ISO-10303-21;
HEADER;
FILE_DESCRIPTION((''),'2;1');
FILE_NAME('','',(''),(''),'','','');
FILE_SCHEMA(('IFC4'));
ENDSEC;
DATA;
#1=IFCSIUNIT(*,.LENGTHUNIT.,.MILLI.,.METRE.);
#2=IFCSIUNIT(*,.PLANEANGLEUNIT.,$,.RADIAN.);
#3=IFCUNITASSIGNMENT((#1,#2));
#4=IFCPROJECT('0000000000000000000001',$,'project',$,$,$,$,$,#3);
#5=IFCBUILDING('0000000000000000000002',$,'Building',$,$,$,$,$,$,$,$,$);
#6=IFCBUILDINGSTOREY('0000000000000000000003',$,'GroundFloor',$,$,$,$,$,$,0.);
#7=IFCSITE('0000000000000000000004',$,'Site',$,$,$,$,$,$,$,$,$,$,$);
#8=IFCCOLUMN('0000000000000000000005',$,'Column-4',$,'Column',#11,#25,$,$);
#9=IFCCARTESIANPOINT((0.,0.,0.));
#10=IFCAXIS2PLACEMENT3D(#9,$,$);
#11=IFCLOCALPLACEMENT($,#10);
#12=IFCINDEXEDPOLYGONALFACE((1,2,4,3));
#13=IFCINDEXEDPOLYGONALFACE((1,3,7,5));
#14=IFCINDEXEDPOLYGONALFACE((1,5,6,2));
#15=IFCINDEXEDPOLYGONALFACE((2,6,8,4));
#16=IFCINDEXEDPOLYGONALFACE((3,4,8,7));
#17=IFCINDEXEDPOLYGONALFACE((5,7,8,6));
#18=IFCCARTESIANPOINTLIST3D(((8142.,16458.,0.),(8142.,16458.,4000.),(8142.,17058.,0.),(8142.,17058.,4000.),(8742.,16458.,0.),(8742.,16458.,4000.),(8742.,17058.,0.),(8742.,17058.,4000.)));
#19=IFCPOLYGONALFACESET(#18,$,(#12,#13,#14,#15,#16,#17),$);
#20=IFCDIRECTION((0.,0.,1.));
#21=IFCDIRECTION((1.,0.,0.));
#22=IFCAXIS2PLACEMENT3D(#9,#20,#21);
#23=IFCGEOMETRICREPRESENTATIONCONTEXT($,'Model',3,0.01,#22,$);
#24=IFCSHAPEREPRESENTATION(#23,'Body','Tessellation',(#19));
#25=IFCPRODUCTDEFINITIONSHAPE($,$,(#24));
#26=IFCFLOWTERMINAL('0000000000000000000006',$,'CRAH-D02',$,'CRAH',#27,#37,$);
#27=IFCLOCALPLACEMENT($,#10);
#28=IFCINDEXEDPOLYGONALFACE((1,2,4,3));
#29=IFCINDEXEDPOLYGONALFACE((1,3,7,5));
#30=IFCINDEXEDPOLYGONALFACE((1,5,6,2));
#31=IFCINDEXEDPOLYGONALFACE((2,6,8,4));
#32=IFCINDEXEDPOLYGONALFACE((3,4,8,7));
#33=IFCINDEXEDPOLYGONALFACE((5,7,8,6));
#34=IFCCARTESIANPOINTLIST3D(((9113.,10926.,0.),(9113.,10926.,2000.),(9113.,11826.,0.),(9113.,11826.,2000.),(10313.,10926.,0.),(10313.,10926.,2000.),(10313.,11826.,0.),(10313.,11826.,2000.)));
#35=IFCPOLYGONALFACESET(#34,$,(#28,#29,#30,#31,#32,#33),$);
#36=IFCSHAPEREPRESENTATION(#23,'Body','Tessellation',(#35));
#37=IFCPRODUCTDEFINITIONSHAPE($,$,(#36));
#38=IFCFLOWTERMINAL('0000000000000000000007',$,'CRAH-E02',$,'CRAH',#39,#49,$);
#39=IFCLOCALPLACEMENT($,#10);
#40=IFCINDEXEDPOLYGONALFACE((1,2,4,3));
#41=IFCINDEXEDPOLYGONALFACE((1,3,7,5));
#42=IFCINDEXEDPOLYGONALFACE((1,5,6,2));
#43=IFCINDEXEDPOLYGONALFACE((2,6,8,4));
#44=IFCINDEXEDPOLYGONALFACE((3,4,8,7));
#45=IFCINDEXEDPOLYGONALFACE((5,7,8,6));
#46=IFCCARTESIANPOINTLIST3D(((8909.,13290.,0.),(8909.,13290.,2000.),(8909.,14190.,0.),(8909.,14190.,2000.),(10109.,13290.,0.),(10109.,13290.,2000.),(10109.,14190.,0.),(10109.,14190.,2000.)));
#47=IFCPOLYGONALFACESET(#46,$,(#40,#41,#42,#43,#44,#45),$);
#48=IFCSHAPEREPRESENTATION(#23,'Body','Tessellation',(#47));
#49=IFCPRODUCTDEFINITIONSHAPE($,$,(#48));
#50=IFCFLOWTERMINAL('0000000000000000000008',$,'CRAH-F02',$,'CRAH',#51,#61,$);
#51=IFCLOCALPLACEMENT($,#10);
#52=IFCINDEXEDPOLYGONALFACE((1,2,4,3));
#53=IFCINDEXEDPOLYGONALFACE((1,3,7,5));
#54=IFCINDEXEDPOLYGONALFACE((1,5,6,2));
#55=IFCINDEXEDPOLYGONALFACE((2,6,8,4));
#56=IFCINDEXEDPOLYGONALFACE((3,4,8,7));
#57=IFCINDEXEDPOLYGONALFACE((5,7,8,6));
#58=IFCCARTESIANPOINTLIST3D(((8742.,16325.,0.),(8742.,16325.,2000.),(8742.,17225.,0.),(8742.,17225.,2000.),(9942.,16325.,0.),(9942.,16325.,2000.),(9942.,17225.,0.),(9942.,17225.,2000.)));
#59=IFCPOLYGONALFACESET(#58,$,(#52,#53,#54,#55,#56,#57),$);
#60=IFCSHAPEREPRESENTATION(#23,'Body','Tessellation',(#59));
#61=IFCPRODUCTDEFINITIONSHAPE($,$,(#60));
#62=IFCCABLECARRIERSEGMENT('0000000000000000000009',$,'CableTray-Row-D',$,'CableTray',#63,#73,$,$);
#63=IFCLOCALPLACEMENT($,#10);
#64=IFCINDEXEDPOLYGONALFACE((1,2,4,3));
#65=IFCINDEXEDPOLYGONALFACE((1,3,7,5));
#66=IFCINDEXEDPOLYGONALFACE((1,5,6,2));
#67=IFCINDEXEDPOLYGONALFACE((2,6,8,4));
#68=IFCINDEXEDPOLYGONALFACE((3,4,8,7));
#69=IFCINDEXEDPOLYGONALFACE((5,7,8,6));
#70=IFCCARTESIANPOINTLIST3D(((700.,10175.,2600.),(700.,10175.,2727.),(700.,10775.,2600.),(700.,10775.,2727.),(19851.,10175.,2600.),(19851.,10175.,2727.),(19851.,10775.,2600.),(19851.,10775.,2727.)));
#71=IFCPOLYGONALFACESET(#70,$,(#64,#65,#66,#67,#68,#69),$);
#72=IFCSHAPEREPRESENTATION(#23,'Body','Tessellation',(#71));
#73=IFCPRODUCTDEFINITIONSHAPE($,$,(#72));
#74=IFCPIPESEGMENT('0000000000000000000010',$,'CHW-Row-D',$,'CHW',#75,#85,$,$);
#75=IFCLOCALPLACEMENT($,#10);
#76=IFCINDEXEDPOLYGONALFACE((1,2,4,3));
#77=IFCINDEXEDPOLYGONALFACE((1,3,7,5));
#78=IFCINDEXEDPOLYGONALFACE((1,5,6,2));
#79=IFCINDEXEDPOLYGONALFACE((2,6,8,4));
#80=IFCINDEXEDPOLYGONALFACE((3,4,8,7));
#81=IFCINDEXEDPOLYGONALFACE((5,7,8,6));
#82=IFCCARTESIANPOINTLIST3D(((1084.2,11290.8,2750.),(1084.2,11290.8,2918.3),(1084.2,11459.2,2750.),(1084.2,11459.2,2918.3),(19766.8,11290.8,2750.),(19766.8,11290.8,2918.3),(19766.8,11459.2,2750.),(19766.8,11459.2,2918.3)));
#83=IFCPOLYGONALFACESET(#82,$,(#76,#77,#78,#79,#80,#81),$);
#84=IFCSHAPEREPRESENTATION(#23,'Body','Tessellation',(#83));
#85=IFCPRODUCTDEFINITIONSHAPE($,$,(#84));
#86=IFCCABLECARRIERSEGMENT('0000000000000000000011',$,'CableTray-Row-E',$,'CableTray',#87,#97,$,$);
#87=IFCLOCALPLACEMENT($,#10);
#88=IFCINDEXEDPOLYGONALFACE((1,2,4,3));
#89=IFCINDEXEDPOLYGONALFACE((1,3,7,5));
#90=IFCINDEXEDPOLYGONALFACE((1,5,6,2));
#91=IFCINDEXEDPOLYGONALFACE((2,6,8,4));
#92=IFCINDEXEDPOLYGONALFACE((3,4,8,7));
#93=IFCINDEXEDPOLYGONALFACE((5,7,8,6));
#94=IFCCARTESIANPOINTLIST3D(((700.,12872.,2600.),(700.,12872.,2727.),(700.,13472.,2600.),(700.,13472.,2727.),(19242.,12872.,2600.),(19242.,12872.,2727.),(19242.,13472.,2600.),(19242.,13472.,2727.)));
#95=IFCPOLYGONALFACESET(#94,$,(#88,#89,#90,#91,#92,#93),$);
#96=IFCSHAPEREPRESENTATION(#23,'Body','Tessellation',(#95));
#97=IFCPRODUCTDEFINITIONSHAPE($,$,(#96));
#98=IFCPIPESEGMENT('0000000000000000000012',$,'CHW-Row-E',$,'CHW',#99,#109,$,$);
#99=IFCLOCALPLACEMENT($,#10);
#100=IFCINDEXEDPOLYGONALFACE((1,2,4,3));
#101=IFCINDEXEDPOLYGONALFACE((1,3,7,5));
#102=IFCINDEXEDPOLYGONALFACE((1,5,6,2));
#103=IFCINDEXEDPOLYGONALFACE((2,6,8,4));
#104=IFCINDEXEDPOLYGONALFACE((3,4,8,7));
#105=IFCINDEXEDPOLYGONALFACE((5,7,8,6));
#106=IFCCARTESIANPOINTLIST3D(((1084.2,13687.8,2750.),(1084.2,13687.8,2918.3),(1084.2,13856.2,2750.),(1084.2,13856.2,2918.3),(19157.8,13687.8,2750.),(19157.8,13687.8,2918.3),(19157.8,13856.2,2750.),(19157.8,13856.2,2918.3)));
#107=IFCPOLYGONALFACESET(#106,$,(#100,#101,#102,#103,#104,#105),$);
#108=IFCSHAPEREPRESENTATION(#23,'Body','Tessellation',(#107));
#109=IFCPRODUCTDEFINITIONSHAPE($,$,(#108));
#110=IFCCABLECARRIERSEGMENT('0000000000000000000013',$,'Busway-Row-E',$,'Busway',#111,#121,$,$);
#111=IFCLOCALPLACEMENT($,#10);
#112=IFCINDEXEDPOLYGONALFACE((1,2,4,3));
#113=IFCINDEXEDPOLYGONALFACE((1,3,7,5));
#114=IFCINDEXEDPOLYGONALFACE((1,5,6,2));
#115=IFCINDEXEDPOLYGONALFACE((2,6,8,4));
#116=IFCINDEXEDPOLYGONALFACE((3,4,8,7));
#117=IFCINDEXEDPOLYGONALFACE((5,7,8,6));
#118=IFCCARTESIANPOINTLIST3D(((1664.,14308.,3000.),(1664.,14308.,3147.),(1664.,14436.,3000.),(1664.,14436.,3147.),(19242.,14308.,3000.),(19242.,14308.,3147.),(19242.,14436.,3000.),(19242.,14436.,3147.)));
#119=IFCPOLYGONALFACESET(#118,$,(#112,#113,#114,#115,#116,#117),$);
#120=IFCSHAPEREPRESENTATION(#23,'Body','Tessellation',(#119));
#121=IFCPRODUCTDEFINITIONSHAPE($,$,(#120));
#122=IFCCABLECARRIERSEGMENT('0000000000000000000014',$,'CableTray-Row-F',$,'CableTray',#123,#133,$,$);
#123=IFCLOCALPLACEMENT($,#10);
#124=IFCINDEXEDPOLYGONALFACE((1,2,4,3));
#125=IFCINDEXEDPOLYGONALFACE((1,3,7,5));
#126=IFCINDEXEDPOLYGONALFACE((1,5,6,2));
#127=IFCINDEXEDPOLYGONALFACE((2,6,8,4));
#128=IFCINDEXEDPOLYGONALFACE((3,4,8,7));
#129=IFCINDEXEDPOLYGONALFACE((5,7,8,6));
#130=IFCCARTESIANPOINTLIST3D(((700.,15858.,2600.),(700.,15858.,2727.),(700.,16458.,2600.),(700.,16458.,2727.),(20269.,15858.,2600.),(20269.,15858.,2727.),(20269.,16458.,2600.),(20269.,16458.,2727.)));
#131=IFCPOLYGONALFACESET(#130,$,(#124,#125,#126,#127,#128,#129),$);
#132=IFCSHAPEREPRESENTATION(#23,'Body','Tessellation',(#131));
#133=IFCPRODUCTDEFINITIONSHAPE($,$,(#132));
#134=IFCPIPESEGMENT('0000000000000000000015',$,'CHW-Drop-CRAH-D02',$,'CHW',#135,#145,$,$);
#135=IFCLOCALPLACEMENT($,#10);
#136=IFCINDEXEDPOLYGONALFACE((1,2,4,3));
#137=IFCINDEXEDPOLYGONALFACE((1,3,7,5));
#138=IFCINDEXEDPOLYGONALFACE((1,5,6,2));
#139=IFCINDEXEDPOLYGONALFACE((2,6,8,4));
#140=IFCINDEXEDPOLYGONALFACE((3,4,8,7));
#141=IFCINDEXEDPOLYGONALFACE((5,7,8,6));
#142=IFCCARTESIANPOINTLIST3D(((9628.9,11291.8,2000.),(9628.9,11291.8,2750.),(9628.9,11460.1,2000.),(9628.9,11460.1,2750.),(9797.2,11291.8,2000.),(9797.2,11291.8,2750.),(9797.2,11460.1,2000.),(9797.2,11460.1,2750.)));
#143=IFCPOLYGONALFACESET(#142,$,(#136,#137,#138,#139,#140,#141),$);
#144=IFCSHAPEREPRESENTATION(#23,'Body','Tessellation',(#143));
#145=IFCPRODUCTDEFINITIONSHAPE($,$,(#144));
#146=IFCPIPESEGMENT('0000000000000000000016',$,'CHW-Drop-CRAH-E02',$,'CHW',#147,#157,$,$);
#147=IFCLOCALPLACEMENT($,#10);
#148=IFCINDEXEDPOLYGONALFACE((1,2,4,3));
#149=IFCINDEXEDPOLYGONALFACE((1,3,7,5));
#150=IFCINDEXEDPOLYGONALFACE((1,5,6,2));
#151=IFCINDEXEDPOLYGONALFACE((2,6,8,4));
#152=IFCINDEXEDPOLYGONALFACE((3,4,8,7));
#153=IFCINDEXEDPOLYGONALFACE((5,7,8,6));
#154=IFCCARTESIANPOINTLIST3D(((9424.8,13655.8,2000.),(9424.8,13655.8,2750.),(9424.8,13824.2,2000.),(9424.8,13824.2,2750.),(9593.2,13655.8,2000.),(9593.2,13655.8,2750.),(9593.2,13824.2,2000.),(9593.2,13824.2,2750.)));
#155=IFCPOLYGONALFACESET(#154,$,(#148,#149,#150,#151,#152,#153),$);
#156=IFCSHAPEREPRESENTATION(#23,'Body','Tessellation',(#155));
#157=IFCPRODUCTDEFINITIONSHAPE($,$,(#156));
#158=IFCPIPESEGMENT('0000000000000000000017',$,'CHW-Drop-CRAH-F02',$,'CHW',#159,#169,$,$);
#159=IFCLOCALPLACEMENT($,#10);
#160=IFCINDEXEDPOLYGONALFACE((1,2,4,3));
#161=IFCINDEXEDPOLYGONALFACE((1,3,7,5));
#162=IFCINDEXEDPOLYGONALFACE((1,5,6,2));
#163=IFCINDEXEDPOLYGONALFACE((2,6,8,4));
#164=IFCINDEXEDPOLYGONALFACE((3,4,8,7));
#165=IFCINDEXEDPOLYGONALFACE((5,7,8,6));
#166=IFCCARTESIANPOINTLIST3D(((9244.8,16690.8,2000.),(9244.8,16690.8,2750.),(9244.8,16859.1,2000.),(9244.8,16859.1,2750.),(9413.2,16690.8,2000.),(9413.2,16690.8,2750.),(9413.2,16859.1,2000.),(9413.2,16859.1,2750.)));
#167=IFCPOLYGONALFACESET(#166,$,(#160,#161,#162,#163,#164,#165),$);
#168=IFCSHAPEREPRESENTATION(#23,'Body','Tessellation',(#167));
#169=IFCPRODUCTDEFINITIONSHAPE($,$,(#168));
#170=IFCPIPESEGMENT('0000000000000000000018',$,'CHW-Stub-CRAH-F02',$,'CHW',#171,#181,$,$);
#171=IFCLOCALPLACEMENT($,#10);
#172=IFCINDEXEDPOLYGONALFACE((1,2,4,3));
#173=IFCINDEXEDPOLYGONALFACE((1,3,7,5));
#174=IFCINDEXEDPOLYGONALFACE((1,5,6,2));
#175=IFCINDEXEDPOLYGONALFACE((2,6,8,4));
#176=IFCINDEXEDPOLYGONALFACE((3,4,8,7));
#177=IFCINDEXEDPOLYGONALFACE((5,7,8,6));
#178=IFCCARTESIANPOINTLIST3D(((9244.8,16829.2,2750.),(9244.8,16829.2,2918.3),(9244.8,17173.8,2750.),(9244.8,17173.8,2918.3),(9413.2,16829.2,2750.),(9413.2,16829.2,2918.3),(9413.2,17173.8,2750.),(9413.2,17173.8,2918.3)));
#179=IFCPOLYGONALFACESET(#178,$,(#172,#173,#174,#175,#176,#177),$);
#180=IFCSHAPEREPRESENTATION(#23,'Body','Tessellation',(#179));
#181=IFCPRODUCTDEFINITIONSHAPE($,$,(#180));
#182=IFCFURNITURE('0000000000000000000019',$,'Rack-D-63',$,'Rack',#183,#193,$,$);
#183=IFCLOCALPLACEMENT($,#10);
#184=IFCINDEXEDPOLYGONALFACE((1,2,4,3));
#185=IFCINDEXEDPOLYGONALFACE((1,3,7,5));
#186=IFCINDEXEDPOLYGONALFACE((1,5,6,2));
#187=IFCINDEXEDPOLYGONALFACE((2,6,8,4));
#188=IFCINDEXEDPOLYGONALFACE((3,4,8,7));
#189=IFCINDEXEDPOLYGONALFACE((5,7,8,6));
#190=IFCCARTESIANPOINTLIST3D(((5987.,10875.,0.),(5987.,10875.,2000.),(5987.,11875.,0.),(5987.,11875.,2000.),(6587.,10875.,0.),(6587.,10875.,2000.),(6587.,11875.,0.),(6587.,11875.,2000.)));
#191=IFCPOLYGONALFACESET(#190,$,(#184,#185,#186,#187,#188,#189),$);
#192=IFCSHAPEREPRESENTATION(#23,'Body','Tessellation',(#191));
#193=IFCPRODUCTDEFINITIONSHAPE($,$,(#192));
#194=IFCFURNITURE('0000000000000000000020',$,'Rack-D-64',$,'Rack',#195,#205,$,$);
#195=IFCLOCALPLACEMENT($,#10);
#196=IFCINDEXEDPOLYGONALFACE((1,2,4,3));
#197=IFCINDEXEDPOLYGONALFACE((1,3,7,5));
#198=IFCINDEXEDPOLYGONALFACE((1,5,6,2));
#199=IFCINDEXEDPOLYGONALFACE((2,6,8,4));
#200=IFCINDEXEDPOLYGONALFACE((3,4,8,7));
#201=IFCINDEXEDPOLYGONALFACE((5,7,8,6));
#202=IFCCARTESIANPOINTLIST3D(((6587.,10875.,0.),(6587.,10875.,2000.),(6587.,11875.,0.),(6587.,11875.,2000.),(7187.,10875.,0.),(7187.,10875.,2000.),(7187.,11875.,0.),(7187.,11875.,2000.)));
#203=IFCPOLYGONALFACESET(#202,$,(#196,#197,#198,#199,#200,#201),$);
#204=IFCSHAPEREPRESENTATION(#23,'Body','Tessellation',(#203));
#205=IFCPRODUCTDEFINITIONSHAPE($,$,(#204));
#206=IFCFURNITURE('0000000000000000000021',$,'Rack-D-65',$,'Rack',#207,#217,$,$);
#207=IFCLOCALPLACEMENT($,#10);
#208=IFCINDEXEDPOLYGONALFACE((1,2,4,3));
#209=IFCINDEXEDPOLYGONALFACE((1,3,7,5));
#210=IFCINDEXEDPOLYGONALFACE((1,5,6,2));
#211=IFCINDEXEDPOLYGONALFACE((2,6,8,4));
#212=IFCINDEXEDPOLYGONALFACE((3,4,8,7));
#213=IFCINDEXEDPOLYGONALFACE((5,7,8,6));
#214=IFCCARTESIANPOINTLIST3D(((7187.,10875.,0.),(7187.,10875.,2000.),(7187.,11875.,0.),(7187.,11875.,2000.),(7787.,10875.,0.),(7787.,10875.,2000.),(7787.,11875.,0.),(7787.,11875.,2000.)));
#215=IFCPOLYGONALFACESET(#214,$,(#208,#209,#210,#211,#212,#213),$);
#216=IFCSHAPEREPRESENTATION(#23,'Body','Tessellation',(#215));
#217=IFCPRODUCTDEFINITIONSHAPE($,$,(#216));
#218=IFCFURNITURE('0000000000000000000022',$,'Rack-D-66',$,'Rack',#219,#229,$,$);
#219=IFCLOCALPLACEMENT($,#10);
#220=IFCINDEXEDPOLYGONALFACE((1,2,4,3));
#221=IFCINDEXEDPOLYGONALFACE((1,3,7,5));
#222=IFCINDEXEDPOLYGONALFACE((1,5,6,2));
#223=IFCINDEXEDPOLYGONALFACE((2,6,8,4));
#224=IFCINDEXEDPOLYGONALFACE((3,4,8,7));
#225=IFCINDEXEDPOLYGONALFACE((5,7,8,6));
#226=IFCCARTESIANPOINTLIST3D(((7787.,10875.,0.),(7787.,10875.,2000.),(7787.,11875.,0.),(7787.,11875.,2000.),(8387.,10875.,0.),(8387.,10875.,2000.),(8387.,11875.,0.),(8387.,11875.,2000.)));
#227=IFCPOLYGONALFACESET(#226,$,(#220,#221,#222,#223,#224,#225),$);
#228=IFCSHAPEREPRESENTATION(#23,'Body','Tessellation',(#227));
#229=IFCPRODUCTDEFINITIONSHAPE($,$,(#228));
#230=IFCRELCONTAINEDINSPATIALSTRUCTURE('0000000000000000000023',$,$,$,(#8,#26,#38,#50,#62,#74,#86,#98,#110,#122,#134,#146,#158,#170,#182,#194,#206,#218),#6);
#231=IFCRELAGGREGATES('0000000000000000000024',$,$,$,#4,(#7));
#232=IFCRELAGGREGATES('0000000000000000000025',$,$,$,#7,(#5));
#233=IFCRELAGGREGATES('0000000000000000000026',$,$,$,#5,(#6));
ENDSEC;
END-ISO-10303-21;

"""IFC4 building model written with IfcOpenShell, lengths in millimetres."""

from ifc_helpers import new_model, si_unit, frame, origin, origin_with_axes, origin_2d, place, context, project, spatial, rectangle, extrude, element, save


model = new_model("IFC4")

# Units and contexts
model_context = context("Model", 3, precision=0.01, world=origin_with_axes())
ifc_project = project(units=[si_unit("LENGTHUNIT", "METRE", prefix="MILLI"), si_unit("PLANEANGLEUNIT", "RADIAN")])

# Site, building, storey
site = spatial("IfcSite", under=ifc_project, Name="Site")
building = spatial("IfcBuilding", under=site, Name="Building")
storey = spatial("IfcBuildingStorey", under=building, Name="GroundFloor", Elevation=0.0)

# Column
column_placement = place(None, frame((8442.0, 16758.0, 0.0), z_axis=(0.0, 0.0, 1.0), x_axis=(1.0, 0.0, 0.0)))
element("IfcColumn", 1, at=column_placement, inside=storey, Name="Column-4", ObjectType="Column", context=model_context, shape_type="SweptSolid", body=[
    extrude(rectangle(XDim=600.0, YDim=600.0, at=origin_2d()), origin(), (0.0, 0.0, 1.0), 4000.0),
])

# Flow terminals
for number, where, z_axis, x_axis, name in (
    (2, (9713.0, 11376.0, 0.0), (0.0, 0.0, 1.0), (1.0, 0.0, 0.0), "CRAH-D02"),
    (3, (9509.0, 13740.0, 0.0), (0.0, 0.0, 1.0), (1.0, 0.0, 0.0), "CRAH-E02"),
    (4, (9342.0, 16775.0, 0.0), (0.0, 0.0, 1.0), (1.0, 0.0, 0.0), "CRAH-F02"),
):
    element("IfcFlowTerminal", number, at=place(None, frame(where, z_axis=z_axis, x_axis=x_axis)), inside=storey, Name=name, ObjectType="CRAH", context=model_context, shape_type="SweptSolid", body=[
        extrude(rectangle(XDim=1200.0, YDim=900.0, at=origin_2d()), origin(), (0.0, 0.0, 1.0), 2000.0),
    ])

# Cable carrier segment
cable_carrier_segment_1_placement = place(None, frame((10275.5, 10475.0, 2600.0), z_axis=(0.0, 0.0, 1.0), x_axis=(1.0, 0.0, 0.0)))
element("IfcCableCarrierSegment", 5, at=cable_carrier_segment_1_placement, inside=storey, Name="CableTray-Row-D", ObjectType="CableTray", context=model_context, shape_type="SweptSolid", body=[
    extrude(rectangle(XDim=19151.0, YDim=600.0, at=origin_2d()), origin(), (0.0, 0.0, 1.0), 127.0),
])

# Pipe segment
pipe_segment_1_placement = place(None, frame((10425.5, 11375.0, 2750.0), z_axis=(0.0, 0.0, 1.0), x_axis=(1.0, 0.0, 0.0)))
element("IfcPipeSegment", 6, at=pipe_segment_1_placement, inside=storey, Name="CHW-Row-D", ObjectType="CHW", context=model_context, shape_type="SweptSolid", body=[
    extrude(rectangle(XDim=18682.7, YDim=168.3, at=origin_2d()), origin(), (0.0, 0.0, 1.0), 168.3),
])

# Cable carrier segment
cable_carrier_segment_2_placement = place(None, frame((9971.0, 13172.0, 2600.0), z_axis=(0.0, 0.0, 1.0), x_axis=(1.0, 0.0, 0.0)))
element("IfcCableCarrierSegment", 7, at=cable_carrier_segment_2_placement, inside=storey, Name="CableTray-Row-E", ObjectType="CableTray", context=model_context, shape_type="SweptSolid", body=[
    extrude(rectangle(XDim=18542.0, YDim=600.0, at=origin_2d()), origin(), (0.0, 0.0, 1.0), 127.0),
])

# Pipe segment
pipe_segment_2_placement = place(None, frame((10121.0, 13772.0, 2750.0), z_axis=(0.0, 0.0, 1.0), x_axis=(1.0, 0.0, 0.0)))
element("IfcPipeSegment", 8, at=pipe_segment_2_placement, inside=storey, Name="CHW-Row-E", ObjectType="CHW", context=model_context, shape_type="SweptSolid", body=[
    extrude(rectangle(XDim=18073.7, YDim=168.3, at=origin_2d()), origin(), (0.0, 0.0, 1.0), 168.3),
])

# Cable carrier segments
cable_carrier_segment_3_placement = place(None, frame((10453.0, 14372.0, 3000.0), z_axis=(0.0, 0.0, 1.0), x_axis=(1.0, 0.0, 0.0)))
element("IfcCableCarrierSegment", 9, at=cable_carrier_segment_3_placement, inside=storey, Name="Busway-Row-E", ObjectType="Busway", context=model_context, shape_type="SweptSolid", body=[
    extrude(rectangle(XDim=17578.0, YDim=128.0, at=origin_2d()), origin(), (0.0, 0.0, 1.0), 147.0),
])
cable_carrier_segment_4_placement = place(None, frame((10484.5, 16158.0, 2600.0), z_axis=(0.0, 0.0, 1.0), x_axis=(1.0, 0.0, 0.0)))
element("IfcCableCarrierSegment", 10, at=cable_carrier_segment_4_placement, inside=storey, Name="CableTray-Row-F", ObjectType="CableTray", context=model_context, shape_type="SweptSolid", body=[
    extrude(rectangle(XDim=19569.0, YDim=600.0, at=origin_2d()), origin(), (0.0, 0.0, 1.0), 127.0),
])

# Pipe segments
for number, where, z_axis, x_axis, name in (
    (11, (9713.0, 11376.0, 2000.0), (0.0, 0.0, 1.0), (1.0, 0.0, 0.0), "CHW-Drop-CRAH-D02"),
    (12, (9509.0, 13740.0, 2000.0), (0.0, 0.0, 1.0), (1.0, 0.0, 0.0), "CHW-Drop-CRAH-E02"),
    (13, (9329.0, 16775.0, 2000.0), (0.0, 0.0, 1.0), (1.0, 0.0, 0.0), "CHW-Drop-CRAH-F02"),
):
    element("IfcPipeSegment", number, at=place(None, frame(where, z_axis=z_axis, x_axis=x_axis)), inside=storey, Name=name, ObjectType="CHW", context=model_context, shape_type="SweptSolid", body=[
        extrude(rectangle(XDim=168.3, YDim=168.3, at=origin_2d()), origin(), (0.0, 0.0, 1.0), 750.0),
    ])
pipe_segment_3_placement = place(None, frame((9329.0, 17001.5, 2750.0), z_axis=(0.0, 0.0, 1.0), x_axis=(1.0, 0.0, 0.0)))
element("IfcPipeSegment", 14, at=pipe_segment_3_placement, inside=storey, Name="CHW-Stub-CRAH-F02", ObjectType="CHW", context=model_context, shape_type="SweptSolid", body=[
    extrude(rectangle(XDim=168.3, YDim=344.7, at=origin_2d()), origin(), (0.0, 0.0, 1.0), 168.3),
])

# Furniture
for number, where, z_axis, x_axis, name in (
    (15, (6287.0, 11375.0, 0.0), (0.0, 0.0, 1.0), (1.0, 0.0, 0.0), "Rack-D-63"),
    (16, (6887.0, 11375.0, 0.0), (0.0, 0.0, 1.0), (1.0, 0.0, 0.0), "Rack-D-64"),
    (17, (7487.0, 11375.0, 0.0), (0.0, 0.0, 1.0), (1.0, 0.0, 0.0), "Rack-D-65"),
    (18, (8087.0, 11375.0, 0.0), (0.0, 0.0, 1.0), (1.0, 0.0, 0.0), "Rack-D-66"),
):
    element("IfcFurniture", number, at=place(None, frame(where, z_axis=z_axis, x_axis=x_axis)), inside=storey, Name=name, ObjectType="Rack", context=model_context, shape_type="SweptSolid", body=[
        extrude(rectangle(XDim=600.0, YDim=1000.0, at=origin_2d()), origin(), (0.0, 0.0, 1.0), 2000.0),
    ])

save(model, "model.ifc")
